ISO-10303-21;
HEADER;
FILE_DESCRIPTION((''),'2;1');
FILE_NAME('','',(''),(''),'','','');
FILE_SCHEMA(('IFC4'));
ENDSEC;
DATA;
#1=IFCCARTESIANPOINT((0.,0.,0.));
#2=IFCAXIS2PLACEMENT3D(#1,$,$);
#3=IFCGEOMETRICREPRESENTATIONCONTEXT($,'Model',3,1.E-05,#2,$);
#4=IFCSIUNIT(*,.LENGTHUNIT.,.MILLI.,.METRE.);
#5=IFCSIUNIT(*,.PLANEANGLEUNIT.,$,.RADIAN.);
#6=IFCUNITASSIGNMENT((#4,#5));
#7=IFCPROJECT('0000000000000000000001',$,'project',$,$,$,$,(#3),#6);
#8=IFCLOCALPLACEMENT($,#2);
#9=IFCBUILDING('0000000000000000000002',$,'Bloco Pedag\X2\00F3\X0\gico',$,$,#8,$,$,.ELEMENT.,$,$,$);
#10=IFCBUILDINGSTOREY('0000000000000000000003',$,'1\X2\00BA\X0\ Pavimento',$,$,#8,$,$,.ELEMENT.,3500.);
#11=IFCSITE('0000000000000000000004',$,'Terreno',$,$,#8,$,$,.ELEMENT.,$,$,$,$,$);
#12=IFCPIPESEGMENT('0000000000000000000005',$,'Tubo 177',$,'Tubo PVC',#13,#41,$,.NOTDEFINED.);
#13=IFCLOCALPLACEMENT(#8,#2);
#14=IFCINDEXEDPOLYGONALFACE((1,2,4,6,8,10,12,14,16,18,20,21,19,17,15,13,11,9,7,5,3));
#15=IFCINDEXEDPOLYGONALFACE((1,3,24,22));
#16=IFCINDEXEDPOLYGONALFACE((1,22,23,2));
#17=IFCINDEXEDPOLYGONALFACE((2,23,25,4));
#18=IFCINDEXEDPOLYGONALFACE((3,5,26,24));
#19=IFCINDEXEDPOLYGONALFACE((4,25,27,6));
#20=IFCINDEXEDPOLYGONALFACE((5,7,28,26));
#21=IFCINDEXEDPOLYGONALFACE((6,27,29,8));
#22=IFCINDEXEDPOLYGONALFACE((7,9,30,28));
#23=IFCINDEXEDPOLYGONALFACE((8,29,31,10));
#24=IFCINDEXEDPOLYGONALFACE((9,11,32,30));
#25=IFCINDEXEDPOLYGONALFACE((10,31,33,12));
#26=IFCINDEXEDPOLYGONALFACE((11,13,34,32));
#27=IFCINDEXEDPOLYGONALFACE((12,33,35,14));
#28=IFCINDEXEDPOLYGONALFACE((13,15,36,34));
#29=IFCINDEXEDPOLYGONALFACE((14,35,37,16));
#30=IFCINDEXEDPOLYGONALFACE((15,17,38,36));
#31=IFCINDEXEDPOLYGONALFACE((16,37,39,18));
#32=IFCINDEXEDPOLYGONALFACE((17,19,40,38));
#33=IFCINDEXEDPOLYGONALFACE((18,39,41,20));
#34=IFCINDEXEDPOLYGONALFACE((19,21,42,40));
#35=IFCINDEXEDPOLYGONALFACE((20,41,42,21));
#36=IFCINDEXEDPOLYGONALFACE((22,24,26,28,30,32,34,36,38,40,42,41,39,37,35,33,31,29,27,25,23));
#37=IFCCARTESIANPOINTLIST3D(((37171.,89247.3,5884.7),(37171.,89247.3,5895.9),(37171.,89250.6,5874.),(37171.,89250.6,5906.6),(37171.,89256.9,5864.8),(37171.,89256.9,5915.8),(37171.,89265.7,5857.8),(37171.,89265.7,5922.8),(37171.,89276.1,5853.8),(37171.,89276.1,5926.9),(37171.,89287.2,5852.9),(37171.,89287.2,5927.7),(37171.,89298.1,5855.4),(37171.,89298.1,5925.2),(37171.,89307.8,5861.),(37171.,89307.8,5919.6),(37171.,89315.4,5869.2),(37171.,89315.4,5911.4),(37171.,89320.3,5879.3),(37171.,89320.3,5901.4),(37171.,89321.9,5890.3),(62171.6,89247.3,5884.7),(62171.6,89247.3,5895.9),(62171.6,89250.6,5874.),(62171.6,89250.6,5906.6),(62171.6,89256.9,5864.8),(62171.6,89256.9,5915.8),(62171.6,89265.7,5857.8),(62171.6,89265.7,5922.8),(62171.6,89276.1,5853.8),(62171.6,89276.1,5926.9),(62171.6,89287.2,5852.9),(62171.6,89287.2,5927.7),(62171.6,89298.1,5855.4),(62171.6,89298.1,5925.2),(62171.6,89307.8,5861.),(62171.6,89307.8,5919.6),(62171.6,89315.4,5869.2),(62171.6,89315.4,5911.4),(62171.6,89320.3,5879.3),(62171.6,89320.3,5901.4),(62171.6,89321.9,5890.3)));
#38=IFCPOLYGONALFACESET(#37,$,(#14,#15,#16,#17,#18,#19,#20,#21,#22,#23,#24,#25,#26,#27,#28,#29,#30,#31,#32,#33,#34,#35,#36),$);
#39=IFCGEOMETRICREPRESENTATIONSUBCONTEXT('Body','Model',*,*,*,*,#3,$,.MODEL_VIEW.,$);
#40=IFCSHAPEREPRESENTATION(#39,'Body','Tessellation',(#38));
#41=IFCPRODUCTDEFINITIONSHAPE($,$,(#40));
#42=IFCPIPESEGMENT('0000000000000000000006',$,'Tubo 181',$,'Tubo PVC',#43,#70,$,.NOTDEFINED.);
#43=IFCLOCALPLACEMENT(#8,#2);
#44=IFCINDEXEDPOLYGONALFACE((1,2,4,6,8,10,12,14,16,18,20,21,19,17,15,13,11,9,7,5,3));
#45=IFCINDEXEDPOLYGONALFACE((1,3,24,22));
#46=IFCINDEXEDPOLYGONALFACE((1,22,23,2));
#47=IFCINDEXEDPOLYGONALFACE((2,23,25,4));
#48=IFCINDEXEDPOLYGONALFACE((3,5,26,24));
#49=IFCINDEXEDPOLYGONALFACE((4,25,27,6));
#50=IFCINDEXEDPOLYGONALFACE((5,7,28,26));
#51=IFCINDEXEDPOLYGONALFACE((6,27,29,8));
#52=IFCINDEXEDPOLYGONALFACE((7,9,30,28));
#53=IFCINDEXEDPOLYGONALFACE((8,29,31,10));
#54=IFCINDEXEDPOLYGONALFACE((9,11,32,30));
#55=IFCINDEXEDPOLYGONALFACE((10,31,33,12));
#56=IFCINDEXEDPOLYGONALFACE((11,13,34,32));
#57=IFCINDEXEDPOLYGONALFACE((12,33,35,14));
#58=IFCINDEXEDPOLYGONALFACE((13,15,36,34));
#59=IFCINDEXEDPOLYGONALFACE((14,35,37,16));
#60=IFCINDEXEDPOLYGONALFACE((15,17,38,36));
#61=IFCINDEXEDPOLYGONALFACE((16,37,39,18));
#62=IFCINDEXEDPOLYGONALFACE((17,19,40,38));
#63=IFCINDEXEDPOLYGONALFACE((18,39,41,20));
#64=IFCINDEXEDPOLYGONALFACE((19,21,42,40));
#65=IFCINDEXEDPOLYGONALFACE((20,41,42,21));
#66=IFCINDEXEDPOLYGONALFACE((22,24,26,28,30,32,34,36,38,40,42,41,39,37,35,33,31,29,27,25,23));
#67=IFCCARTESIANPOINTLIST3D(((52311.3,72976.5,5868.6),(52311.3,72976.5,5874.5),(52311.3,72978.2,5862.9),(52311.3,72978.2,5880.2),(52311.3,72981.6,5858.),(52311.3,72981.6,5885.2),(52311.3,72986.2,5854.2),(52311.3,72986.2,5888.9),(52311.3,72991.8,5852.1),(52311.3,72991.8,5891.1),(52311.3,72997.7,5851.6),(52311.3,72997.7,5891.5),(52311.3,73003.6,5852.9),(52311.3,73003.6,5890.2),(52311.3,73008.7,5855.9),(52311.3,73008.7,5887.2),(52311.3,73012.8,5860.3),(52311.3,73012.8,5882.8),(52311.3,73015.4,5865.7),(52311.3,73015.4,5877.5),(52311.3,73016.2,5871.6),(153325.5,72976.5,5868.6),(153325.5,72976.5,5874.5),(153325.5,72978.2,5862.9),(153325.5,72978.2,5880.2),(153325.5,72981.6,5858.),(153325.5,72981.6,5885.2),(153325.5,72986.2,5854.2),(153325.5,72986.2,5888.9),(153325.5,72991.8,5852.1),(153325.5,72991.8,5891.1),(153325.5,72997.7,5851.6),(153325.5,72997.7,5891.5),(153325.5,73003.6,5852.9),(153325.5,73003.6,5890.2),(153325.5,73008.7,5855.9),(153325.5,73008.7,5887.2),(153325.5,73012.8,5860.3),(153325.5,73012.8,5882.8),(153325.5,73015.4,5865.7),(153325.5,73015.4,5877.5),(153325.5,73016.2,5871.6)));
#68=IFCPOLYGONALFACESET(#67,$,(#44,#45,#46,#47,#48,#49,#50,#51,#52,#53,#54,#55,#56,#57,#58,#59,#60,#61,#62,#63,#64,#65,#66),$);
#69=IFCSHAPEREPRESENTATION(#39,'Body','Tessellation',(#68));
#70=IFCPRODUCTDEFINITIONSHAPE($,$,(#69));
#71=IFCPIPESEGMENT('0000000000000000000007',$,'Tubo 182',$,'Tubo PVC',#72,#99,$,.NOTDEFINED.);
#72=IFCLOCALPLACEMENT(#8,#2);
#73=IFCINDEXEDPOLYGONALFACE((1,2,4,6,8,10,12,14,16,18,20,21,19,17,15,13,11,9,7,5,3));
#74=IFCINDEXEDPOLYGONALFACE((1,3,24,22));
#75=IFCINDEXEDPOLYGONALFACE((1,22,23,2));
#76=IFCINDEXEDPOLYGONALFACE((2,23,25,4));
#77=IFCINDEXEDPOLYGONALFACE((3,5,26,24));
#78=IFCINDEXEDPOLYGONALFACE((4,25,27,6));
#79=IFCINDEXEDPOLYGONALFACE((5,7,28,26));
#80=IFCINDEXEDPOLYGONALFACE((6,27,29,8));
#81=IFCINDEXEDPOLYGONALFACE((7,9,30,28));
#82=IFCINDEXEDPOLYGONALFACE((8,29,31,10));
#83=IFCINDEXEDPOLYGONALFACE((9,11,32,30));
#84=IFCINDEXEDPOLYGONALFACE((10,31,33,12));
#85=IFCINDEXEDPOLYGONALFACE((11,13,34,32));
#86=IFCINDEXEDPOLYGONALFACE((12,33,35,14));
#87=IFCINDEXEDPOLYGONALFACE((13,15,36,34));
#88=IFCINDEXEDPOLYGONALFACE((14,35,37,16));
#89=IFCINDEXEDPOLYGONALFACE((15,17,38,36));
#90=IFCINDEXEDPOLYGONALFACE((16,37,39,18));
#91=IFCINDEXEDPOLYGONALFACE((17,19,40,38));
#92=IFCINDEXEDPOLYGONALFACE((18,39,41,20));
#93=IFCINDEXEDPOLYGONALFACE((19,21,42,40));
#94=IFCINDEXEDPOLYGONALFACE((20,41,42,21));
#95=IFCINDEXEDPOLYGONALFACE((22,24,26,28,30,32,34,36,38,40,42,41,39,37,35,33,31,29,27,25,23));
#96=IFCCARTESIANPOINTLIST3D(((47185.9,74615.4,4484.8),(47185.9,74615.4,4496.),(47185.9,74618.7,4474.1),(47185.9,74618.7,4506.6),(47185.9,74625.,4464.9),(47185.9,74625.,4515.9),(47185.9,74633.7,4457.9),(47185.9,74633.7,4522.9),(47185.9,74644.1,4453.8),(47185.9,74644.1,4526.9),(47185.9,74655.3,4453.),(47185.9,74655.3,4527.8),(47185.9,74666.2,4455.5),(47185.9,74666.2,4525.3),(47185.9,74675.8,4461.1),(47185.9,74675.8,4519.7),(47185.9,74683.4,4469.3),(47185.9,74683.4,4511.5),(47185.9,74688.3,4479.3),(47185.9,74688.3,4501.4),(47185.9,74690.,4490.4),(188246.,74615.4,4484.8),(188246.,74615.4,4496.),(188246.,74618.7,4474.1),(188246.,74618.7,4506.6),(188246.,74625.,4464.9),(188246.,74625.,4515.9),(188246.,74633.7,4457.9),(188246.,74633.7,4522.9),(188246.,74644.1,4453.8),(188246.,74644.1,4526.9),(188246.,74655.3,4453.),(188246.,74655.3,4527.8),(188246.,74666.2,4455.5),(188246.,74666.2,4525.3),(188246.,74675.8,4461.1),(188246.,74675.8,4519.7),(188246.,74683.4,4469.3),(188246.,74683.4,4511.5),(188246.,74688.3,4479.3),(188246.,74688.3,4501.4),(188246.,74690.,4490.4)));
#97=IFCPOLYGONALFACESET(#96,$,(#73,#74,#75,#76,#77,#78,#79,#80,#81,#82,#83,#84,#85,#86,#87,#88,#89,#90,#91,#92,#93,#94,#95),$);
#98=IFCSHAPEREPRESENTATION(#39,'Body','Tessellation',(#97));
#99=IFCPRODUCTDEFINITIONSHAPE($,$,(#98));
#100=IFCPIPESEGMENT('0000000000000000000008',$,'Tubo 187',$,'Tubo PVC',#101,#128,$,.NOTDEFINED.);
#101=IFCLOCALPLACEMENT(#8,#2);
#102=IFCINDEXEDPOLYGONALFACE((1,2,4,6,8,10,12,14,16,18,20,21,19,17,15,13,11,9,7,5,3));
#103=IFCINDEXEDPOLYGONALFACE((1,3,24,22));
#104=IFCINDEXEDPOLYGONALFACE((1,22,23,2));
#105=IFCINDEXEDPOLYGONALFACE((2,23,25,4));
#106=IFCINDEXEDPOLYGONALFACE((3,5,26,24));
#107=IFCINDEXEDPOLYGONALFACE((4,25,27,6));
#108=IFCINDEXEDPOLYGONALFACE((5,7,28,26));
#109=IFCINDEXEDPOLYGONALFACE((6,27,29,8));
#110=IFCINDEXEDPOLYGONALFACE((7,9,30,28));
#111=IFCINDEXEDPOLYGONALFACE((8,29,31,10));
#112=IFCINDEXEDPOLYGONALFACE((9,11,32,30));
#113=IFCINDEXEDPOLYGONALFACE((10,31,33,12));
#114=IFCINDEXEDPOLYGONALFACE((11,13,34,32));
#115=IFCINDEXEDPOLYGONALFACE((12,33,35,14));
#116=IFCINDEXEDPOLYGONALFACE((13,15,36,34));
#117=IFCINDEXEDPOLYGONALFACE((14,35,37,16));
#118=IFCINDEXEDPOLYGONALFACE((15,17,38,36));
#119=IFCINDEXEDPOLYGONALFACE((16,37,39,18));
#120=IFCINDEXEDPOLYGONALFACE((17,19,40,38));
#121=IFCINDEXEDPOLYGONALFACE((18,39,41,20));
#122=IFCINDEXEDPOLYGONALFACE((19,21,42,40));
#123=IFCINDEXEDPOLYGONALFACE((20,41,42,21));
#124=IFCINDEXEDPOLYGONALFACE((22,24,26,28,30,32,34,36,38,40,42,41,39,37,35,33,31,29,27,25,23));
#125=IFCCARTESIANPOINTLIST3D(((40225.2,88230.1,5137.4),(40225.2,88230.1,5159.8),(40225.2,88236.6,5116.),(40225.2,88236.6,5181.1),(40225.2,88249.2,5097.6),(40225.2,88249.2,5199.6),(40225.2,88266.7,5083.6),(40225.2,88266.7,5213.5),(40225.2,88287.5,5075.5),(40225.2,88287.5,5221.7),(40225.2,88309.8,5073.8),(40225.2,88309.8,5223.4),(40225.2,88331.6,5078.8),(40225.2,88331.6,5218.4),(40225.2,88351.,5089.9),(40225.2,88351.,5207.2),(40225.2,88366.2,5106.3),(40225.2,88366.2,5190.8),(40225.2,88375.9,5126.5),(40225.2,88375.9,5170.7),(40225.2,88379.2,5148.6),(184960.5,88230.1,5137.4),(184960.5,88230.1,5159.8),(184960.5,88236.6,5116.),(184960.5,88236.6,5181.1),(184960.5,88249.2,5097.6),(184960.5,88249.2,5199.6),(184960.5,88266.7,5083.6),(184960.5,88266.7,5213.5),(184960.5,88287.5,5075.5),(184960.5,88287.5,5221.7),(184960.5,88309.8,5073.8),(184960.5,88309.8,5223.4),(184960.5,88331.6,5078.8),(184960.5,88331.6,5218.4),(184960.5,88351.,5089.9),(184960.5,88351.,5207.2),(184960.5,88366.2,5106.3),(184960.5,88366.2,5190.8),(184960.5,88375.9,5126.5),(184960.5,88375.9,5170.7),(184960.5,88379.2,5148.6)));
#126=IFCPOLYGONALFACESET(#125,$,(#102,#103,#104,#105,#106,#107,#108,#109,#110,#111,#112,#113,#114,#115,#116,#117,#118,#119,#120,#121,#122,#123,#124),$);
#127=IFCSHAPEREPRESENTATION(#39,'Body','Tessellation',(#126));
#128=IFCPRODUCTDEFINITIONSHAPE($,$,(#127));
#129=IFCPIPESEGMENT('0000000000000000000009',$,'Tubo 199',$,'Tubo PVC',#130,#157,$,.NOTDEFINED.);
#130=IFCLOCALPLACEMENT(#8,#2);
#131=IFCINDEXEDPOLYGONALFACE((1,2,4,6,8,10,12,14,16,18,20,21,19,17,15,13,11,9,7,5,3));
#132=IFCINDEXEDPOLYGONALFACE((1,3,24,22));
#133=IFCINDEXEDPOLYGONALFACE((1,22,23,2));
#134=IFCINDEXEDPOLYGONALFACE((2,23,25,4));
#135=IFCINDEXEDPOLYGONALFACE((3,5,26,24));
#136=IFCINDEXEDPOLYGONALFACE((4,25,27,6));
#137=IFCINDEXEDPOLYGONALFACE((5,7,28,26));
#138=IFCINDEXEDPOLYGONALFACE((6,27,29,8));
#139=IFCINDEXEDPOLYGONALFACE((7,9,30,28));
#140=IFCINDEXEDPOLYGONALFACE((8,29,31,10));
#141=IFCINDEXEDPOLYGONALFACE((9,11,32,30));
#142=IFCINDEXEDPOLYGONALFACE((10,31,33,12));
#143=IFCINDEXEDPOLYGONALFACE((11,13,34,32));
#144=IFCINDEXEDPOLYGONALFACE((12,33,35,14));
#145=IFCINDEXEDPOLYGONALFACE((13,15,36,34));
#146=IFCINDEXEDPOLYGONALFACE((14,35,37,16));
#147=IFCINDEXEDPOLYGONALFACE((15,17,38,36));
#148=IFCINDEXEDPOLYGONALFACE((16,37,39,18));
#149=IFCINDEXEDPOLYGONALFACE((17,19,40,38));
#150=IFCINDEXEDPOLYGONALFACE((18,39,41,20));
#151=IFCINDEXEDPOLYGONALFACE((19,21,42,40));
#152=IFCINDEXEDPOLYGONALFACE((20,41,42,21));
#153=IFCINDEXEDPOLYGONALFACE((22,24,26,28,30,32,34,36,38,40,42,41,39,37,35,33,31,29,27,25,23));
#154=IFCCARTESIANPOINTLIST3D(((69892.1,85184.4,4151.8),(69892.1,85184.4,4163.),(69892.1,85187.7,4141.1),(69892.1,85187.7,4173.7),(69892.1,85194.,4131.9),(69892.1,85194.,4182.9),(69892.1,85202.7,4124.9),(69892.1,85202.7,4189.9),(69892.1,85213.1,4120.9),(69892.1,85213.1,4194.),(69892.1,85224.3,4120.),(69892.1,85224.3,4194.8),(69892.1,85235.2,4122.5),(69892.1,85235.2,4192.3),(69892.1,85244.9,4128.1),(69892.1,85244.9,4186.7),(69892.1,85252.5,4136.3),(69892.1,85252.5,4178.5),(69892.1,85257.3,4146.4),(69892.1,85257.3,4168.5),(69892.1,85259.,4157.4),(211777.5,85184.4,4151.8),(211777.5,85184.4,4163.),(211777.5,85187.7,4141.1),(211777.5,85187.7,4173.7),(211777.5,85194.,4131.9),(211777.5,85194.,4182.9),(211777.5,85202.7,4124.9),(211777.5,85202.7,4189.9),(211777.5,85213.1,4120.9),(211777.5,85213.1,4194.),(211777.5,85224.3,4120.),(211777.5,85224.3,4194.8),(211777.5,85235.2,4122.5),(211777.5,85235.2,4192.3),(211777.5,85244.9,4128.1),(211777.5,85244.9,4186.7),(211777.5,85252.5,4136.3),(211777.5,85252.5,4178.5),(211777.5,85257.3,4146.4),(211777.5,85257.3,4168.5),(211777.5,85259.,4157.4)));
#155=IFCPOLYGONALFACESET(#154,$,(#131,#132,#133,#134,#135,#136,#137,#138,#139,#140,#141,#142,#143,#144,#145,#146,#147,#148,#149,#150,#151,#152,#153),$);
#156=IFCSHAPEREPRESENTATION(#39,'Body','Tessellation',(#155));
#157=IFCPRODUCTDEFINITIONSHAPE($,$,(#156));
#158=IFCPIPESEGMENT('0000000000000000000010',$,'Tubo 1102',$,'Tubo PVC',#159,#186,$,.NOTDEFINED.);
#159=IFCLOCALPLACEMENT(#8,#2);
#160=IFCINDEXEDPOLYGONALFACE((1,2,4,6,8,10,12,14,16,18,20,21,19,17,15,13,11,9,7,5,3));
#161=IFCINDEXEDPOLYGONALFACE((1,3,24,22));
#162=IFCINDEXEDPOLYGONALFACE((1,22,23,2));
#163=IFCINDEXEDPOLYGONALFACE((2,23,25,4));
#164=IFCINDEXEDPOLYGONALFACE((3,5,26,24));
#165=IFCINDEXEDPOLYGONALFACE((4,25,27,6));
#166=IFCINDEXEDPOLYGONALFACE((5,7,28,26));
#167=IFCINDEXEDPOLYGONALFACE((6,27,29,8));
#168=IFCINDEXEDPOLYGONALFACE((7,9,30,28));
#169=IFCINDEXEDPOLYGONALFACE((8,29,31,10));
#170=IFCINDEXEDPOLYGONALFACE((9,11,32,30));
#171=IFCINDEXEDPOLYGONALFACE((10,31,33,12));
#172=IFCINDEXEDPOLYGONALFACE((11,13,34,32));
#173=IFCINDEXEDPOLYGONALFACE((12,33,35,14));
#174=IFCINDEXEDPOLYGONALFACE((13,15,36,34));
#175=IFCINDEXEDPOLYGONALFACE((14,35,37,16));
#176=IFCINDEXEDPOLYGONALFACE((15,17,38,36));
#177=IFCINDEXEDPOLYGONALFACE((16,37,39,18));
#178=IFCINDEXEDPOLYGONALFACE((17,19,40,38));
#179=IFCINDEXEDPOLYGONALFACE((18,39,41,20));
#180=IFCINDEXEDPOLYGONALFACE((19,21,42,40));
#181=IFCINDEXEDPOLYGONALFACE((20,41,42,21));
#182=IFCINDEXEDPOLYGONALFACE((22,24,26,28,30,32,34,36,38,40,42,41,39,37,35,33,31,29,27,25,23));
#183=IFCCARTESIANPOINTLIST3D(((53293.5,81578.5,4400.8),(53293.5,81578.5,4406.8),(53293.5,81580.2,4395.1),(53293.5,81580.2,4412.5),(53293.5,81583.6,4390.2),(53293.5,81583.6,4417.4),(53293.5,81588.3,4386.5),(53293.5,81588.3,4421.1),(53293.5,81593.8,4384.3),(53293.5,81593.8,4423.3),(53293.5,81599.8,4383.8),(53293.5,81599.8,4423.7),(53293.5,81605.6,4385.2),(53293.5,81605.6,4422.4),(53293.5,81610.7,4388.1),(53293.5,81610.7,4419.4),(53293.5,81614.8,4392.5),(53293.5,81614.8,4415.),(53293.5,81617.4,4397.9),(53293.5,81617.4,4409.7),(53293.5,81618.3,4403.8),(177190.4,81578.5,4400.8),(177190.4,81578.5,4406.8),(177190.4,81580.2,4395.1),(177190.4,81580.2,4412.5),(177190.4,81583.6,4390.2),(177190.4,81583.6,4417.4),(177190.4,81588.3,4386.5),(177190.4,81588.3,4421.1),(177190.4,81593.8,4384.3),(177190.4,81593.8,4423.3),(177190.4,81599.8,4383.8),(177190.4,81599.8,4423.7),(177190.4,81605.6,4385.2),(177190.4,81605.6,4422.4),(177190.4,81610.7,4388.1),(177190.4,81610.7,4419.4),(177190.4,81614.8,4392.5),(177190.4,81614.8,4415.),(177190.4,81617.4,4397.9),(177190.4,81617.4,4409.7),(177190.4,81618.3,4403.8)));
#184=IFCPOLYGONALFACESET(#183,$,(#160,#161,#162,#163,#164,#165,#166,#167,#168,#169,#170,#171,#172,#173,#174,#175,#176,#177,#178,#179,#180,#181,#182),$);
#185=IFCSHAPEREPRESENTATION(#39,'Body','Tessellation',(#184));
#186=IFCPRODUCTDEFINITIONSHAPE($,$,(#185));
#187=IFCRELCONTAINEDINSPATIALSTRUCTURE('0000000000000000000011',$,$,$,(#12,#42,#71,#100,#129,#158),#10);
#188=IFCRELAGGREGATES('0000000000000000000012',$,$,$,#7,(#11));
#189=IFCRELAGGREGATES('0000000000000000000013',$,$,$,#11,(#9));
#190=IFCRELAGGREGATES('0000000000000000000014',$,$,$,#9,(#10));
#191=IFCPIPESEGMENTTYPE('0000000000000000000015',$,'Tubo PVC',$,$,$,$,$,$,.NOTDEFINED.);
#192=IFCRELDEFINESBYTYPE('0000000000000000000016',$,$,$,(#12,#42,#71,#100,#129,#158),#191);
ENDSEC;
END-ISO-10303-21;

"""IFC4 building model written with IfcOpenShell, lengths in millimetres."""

from ifc_helpers import new_model, si_unit, frame, origin, origin_2d, place, context, subcontext, project, spatial, circle, extrude, type_object, element, save


model = new_model("IFC4")

# Units and contexts
model_context = context("Model", 3, precision=1e-05, world=origin())
body_context = subcontext(model_context, "Body", "Model", "MODEL_VIEW")
ifc_project = project(units=[si_unit("LENGTHUNIT", "METRE", prefix="MILLI"), si_unit("PLANEANGLEUNIT", "RADIAN")], contexts=[model_context])

# Site, building, storey
placement = place(None, origin())
site = spatial("IfcSite", under=ifc_project, at=placement, Name="Terreno", CompositionType="ELEMENT")
building = spatial("IfcBuilding", under=site, at=placement, Name="Bloco Pedagógico", CompositionType="ELEMENT")
storey = spatial("IfcBuildingStorey", under=building, at=placement, Name="1º Pavimento", CompositionType="ELEMENT", Elevation=3500.0)

# Pipe segments
pipe_segment_type = type_object("IfcPipeSegmentType", Name="Tubo PVC", PredefinedType="NOTDEFINED")
pipe_segment_1_placement = place(None, frame((37171.0, 89284.4, 5890.3), z_axis=(1.0, 0.0, 0.0), x_axis=(0.0, 1.0, 0.0)))
element("IfcPipeSegment", 1, at=pipe_segment_1_placement, inside=storey, type_object=pipe_segment_type, Name="Tubo 177", ObjectType="Tubo PVC", PredefinedType="NOTDEFINED", context=body_context, shape_type="SweptSolid", body=[
    extrude(circle(Radius=37.5, at=origin_2d()), None, (0.0, 0.0, 1.0), 25000.6),
])
pipe_segment_2_placement = place(None, frame((52311.3, 72996.2, 5871.6), z_axis=(1.0, 0.0, 0.0), x_axis=(0.0, 1.0, 0.0)))
element("IfcPipeSegment", 2, at=pipe_segment_2_placement, inside=storey, type_object=pipe_segment_type, Name="Tubo 181", ObjectType="Tubo PVC", PredefinedType="NOTDEFINED", context=body_context, shape_type="SweptSolid", body=[
    extrude(circle(Radius=20.0, at=origin_2d()), None, (0.0, 0.0, 1.0), 101014.2),
])
pipe_segment_3_placement = place(None, frame((47185.9, 74652.5, 4490.4), z_axis=(1.0, 0.0, 0.0), x_axis=(0.0, 1.0, 0.0)))
element("IfcPipeSegment", 3, at=pipe_segment_3_placement, inside=storey, type_object=pipe_segment_type, Name="Tubo 182", ObjectType="Tubo PVC", PredefinedType="NOTDEFINED", context=body_context, shape_type="SweptSolid", body=[
    extrude(circle(Radius=37.5, at=origin_2d()), None, (0.0, 0.0, 1.0), 141060.0),
])
pipe_segment_4_placement = place(None, frame((40225.2, 88304.2, 5148.6), z_axis=(1.0, 0.0, 0.0), x_axis=(0.0, 1.0, 0.0)))
element("IfcPipeSegment", 4, at=pipe_segment_4_placement, inside=storey, type_object=pipe_segment_type, Name="Tubo 187", ObjectType="Tubo PVC", PredefinedType="NOTDEFINED", context=body_context, shape_type="SweptSolid", body=[
    extrude(circle(Radius=75.0, at=origin_2d()), None, (0.0, 0.0, 1.0), 144735.3),
])
pipe_segment_5_placement = place(None, frame((69892.1, 85221.5, 4157.4), z_axis=(1.0, 0.0, 0.0), x_axis=(0.0, 1.0, 0.0)))
element("IfcPipeSegment", 5, at=pipe_segment_5_placement, inside=storey, type_object=pipe_segment_type, Name="Tubo 199", ObjectType="Tubo PVC", PredefinedType="NOTDEFINED", context=body_context, shape_type="SweptSolid", body=[
    extrude(circle(Radius=37.5, at=origin_2d()), None, (0.0, 0.0, 1.0), 141885.4),
])
pipe_segment_6_placement = place(None, frame((53293.5, 81598.3, 4403.8), z_axis=(1.0, 0.0, 0.0), x_axis=(0.0, 1.0, 0.0)))
element("IfcPipeSegment", 6, at=pipe_segment_6_placement, inside=storey, type_object=pipe_segment_type, Name="Tubo 1102", ObjectType="Tubo PVC", PredefinedType="NOTDEFINED", context=body_context, shape_type="SweptSolid", body=[
    extrude(circle(Radius=20.0, at=origin_2d()), None, (0.0, 0.0, 1.0), 123897.0),
])

save(model, "model.ifc")
